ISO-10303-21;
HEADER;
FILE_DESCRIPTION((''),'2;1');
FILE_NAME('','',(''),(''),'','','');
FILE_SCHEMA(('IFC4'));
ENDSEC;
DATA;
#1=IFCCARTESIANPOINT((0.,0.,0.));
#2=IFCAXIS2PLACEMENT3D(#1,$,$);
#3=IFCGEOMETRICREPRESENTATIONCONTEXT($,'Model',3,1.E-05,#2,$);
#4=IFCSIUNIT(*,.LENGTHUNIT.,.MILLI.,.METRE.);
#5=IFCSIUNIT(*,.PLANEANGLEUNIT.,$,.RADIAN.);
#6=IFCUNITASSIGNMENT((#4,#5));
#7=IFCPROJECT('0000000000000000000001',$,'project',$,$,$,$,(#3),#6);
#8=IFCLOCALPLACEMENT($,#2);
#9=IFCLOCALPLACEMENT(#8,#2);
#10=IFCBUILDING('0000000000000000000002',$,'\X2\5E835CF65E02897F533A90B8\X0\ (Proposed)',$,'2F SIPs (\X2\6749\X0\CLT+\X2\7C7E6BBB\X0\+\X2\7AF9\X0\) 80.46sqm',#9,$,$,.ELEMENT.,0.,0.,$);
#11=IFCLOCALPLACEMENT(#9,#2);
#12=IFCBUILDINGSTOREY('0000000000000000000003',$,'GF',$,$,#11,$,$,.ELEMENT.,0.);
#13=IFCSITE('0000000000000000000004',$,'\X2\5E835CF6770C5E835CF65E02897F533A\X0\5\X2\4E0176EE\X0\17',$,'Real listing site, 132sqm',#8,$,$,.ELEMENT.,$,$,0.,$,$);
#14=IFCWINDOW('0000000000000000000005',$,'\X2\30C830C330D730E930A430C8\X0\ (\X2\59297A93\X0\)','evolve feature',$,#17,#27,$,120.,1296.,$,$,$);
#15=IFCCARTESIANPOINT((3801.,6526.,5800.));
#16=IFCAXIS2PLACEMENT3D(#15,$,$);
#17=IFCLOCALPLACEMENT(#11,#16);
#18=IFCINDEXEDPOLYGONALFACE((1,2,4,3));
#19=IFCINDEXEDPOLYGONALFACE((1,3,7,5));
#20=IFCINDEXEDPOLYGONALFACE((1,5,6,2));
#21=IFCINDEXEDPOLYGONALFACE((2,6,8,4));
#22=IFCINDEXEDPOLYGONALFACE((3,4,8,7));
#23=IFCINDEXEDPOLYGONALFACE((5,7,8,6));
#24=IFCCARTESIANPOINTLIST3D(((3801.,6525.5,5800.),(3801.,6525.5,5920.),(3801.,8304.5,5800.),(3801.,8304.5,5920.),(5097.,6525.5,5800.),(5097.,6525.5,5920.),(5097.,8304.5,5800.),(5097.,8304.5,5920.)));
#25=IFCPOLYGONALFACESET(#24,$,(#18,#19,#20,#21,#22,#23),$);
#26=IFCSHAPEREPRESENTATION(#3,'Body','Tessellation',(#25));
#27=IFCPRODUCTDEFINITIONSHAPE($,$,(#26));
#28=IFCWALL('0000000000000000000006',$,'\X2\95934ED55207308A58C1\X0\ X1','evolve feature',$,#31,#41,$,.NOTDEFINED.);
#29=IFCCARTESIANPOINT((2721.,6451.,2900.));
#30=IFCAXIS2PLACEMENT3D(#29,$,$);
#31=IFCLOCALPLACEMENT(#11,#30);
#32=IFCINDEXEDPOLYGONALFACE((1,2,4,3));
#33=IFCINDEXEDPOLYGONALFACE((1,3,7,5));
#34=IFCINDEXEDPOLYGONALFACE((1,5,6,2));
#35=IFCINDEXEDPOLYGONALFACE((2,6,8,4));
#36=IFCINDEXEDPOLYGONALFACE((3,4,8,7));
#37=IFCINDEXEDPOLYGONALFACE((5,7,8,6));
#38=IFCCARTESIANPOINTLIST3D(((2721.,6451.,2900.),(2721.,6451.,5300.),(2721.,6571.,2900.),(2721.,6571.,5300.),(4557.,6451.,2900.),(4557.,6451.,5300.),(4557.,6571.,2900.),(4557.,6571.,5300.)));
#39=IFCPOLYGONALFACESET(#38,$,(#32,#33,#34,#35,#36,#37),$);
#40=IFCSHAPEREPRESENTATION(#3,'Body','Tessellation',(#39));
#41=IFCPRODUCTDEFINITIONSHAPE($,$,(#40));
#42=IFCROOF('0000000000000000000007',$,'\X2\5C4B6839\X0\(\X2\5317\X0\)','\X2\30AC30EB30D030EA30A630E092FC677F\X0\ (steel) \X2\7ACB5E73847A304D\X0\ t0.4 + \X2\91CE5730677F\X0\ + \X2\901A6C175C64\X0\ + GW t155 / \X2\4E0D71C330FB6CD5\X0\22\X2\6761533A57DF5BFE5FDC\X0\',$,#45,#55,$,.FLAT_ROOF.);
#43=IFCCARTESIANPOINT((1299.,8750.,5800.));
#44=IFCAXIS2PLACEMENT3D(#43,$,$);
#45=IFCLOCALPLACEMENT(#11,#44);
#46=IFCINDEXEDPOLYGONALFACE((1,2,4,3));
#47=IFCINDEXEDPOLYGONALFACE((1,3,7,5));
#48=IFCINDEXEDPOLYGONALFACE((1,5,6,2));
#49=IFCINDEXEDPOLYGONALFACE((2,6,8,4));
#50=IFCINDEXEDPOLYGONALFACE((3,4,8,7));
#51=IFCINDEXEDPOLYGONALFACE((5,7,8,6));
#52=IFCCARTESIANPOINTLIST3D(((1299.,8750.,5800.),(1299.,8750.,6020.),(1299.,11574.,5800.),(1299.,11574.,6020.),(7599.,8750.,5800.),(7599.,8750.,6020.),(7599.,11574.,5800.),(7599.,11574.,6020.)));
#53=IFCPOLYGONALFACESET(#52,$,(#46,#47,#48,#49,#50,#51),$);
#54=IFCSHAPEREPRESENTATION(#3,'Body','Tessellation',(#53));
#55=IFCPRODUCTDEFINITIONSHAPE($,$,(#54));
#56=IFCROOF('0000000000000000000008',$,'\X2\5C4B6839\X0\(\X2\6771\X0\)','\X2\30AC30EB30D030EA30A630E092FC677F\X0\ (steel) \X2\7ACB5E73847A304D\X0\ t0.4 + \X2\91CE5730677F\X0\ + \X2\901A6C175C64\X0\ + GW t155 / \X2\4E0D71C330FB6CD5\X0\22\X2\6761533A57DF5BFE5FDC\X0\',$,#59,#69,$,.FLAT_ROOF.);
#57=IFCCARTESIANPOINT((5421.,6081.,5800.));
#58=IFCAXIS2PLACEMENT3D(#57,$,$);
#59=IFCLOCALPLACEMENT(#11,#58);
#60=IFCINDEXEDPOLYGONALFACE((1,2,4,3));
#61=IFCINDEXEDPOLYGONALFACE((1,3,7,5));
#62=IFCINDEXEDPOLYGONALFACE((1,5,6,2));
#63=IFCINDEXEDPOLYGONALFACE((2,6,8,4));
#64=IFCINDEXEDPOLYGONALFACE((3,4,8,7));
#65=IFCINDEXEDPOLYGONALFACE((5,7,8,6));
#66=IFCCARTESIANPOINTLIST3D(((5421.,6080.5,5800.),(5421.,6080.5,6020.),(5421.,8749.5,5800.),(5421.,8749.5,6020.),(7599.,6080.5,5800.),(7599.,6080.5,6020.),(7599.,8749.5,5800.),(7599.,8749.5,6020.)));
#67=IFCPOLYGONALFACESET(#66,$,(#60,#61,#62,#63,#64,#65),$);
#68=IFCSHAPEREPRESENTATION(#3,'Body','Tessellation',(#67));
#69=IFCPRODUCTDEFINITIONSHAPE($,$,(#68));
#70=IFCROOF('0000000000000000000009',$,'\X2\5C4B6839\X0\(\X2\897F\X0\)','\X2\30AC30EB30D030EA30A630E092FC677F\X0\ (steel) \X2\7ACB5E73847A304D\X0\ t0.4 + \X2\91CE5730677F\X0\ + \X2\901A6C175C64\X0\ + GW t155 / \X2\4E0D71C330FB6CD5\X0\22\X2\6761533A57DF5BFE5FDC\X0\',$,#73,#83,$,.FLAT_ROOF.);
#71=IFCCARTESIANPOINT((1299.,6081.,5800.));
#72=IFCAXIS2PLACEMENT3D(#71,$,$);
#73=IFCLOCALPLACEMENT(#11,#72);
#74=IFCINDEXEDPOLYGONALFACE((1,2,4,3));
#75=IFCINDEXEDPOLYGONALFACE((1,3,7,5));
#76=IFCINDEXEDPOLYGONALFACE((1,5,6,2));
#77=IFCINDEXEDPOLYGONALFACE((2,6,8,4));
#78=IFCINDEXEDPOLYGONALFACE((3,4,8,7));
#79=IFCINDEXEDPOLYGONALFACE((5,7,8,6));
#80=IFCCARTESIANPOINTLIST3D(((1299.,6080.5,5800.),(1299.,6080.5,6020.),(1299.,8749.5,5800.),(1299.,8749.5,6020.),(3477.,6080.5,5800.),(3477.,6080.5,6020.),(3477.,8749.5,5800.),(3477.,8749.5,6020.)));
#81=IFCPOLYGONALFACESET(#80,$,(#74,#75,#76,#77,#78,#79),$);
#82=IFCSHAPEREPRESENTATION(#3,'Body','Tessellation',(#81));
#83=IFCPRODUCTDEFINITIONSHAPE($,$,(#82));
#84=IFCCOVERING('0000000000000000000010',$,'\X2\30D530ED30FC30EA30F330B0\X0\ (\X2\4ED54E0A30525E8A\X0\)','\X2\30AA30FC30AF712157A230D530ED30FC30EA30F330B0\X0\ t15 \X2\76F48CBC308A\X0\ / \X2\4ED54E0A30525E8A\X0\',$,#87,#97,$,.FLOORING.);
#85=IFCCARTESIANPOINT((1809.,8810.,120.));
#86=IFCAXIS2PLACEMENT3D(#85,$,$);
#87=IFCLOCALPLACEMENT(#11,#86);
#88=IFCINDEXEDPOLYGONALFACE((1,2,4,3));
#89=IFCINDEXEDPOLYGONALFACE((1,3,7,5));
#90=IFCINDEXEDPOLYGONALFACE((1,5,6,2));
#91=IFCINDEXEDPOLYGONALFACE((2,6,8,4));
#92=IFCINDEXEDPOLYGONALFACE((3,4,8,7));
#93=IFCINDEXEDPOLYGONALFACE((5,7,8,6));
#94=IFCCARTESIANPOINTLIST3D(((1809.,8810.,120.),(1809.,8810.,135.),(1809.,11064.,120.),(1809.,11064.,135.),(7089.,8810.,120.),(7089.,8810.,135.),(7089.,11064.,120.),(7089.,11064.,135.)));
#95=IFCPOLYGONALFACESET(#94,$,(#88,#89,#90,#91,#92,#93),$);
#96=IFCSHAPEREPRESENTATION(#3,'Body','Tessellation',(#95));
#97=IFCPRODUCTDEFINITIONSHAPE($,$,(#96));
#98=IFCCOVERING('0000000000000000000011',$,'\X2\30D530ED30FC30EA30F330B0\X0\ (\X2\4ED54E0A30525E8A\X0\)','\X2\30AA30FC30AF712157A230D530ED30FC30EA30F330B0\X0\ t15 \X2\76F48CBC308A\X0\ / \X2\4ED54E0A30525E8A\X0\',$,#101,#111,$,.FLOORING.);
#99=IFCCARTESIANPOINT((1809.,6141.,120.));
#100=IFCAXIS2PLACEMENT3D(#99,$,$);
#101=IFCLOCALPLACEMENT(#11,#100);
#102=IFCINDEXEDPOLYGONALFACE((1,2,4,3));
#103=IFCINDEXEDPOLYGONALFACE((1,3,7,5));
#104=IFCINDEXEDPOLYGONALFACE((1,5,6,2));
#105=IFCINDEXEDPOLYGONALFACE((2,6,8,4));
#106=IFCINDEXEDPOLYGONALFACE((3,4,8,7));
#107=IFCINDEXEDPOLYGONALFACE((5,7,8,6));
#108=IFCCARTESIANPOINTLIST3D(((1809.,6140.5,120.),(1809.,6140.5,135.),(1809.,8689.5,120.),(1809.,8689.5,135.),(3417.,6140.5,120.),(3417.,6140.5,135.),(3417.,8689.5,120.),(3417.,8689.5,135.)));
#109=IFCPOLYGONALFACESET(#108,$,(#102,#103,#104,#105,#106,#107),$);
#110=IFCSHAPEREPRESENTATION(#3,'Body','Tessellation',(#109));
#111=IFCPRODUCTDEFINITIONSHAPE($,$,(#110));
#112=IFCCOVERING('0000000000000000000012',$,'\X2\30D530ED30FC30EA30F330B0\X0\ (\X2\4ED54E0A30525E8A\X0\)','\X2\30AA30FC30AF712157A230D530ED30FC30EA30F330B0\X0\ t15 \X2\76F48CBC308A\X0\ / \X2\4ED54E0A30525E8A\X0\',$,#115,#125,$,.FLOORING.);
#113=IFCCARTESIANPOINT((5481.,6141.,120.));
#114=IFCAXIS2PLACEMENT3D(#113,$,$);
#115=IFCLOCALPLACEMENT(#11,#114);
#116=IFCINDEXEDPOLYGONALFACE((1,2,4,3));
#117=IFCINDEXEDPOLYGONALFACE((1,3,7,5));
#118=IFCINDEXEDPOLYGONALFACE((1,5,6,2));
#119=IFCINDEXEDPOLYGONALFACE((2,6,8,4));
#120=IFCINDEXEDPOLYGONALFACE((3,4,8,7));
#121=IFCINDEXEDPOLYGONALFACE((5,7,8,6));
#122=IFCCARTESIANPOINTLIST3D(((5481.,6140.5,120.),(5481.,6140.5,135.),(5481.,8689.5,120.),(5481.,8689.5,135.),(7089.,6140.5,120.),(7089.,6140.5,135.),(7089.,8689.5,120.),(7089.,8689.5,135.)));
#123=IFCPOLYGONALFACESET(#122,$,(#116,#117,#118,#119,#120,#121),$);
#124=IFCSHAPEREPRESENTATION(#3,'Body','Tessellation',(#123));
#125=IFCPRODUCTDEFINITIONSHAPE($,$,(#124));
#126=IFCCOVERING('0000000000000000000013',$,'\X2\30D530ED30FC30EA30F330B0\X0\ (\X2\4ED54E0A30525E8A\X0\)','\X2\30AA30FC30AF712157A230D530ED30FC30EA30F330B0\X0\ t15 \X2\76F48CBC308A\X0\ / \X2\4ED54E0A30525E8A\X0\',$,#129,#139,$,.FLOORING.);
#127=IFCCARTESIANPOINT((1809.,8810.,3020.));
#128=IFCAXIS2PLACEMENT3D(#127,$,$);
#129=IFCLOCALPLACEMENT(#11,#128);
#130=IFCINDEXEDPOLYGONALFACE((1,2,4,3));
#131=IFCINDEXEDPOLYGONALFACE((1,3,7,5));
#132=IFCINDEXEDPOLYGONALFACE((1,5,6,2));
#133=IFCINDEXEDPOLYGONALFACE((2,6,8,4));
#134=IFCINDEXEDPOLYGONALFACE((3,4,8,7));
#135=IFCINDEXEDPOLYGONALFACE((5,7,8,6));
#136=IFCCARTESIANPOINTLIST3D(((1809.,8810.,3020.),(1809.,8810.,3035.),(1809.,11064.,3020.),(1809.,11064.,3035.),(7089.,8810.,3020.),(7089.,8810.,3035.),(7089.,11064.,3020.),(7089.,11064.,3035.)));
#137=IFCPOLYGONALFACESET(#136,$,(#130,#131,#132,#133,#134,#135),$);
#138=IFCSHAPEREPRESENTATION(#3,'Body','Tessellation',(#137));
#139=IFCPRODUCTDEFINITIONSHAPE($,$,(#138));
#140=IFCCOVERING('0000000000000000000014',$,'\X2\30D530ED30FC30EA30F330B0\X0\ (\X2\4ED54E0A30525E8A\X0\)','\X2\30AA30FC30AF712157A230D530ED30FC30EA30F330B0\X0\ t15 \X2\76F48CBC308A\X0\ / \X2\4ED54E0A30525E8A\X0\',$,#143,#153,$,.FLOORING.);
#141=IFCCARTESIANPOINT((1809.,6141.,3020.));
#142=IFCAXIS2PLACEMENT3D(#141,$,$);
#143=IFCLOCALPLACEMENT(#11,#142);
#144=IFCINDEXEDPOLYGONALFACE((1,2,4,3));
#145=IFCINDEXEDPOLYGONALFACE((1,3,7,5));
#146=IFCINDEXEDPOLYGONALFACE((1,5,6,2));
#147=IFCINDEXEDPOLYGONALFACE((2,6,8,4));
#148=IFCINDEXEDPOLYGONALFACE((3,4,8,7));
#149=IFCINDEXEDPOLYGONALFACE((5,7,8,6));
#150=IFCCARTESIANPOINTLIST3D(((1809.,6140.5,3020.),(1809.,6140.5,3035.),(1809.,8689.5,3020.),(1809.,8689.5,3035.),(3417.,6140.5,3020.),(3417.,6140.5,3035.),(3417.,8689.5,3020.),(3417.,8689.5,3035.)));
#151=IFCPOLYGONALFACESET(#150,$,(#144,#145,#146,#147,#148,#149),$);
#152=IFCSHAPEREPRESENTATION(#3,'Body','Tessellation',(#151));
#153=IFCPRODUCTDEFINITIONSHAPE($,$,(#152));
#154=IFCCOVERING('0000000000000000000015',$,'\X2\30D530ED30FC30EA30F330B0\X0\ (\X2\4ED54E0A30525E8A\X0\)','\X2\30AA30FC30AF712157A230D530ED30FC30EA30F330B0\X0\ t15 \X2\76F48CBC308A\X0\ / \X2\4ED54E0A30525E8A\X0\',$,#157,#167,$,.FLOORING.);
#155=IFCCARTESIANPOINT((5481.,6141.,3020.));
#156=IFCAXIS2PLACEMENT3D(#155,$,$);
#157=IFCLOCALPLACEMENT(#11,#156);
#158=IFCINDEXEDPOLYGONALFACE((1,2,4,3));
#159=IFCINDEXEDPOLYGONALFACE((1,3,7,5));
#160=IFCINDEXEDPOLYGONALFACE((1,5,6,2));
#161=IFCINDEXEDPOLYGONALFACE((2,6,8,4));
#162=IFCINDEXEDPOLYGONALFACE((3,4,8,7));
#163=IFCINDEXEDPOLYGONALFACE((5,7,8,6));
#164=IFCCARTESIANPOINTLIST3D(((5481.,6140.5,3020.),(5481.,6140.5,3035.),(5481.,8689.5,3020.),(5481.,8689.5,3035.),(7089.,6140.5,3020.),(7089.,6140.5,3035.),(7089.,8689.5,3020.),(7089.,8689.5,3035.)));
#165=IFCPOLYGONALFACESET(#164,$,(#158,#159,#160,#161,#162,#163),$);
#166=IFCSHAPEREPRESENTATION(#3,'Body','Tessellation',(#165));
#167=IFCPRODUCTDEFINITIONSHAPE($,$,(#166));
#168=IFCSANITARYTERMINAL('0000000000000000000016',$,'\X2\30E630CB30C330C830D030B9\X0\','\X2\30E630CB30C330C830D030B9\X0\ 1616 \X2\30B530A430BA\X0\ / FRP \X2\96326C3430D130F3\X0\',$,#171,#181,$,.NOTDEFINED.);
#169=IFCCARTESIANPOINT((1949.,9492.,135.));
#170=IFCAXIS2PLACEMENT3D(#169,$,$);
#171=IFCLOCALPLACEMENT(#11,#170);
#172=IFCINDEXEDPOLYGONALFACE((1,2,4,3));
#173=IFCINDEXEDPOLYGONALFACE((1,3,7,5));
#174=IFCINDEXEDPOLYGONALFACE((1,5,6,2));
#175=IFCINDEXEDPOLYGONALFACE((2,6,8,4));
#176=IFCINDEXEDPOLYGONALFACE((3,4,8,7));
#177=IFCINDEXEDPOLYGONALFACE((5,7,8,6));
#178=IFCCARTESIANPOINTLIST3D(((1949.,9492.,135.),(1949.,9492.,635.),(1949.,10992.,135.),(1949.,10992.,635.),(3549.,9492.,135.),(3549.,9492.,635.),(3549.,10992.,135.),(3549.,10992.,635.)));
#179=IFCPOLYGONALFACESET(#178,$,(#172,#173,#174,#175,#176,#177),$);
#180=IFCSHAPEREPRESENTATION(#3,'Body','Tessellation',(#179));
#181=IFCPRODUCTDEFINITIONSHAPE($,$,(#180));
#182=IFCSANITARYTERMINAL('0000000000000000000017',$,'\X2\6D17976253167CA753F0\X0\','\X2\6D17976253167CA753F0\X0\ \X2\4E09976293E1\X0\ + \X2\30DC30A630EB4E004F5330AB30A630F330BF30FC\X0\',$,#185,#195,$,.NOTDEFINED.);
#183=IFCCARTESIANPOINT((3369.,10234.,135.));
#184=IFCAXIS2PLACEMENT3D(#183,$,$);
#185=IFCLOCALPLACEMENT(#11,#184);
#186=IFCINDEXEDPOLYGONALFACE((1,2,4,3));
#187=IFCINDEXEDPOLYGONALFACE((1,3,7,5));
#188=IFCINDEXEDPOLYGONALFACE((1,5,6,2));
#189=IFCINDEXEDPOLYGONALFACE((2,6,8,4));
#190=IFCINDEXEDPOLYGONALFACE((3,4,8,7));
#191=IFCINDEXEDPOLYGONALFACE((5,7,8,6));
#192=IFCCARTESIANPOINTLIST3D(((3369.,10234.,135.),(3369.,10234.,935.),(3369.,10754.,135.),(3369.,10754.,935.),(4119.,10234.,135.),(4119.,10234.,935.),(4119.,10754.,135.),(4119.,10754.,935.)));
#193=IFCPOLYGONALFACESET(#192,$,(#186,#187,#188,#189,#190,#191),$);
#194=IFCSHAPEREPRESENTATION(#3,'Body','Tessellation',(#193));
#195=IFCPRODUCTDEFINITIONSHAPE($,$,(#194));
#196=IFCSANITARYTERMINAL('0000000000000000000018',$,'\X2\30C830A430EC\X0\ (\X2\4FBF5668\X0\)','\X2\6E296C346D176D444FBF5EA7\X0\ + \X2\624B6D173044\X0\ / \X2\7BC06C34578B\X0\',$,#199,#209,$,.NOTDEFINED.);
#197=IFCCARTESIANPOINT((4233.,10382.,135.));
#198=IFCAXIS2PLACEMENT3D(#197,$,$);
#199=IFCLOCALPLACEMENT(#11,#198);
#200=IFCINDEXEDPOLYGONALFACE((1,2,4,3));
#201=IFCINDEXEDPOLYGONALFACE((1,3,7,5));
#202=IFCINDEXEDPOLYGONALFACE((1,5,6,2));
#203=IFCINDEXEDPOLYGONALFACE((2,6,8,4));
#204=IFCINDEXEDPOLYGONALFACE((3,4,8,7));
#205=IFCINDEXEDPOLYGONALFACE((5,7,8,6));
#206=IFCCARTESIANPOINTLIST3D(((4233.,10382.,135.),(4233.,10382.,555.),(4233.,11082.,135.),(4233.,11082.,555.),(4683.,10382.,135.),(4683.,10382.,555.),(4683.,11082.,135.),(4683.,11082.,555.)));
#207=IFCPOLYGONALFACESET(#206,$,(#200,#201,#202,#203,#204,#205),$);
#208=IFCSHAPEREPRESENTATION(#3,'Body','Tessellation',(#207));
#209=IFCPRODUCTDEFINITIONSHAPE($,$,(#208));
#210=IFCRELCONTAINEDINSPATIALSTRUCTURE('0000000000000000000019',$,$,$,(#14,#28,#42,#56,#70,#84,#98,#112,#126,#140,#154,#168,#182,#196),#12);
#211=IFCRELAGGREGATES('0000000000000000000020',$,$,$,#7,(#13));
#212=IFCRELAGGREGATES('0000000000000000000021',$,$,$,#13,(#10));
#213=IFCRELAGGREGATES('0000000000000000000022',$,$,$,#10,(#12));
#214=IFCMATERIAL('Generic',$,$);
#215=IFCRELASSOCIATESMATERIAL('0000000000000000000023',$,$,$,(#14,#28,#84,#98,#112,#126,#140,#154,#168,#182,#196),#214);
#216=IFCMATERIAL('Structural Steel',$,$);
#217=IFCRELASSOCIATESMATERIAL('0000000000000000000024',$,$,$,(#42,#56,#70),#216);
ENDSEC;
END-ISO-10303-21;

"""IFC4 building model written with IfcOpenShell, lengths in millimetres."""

from ifc_helpers import new_model, si_unit, frame, frame_2d, origin, place, context, project, spatial, rectangle, extrude, material, element, save


model = new_model("IFC4")

# Units and contexts
model_context = context("Model", 3, precision=1e-05, world=origin())
ifc_project = project(units=[si_unit("LENGTHUNIT", "METRE", prefix="MILLI"), si_unit("PLANEANGLEUNIT", "RADIAN")], contexts=[model_context])

# Site, building, storey
site_placement = place(None, origin())
site = spatial("IfcSite", under=ifc_project, at=site_placement, Name="広島県広島市西区5丁目17", ObjectType="Real listing site, 132sqm", CompositionType="ELEMENT", RefElevation=0.0)
building_placement = place(site_placement, origin())
building = spatial("IfcBuilding", under=site, at=building_placement, Name="広島市西区邸 (Proposed)", ObjectType="2F SIPs (杉CLT+籾殻+竹) 80.46sqm", CompositionType="ELEMENT", ElevationOfRefHeight=0.0, ElevationOfTerrain=0.0)
storey_placement = place(building_placement, origin())
storey = spatial("IfcBuildingStorey", under=building, at=storey_placement, Name="GF", CompositionType="ELEMENT", Elevation=0.0)

# Window
ifc_material_1 = material(Name="Generic")
window_1_placement = place(storey_placement, frame((3801.0, 6526.0, 5800.0)))
element("IfcWindow", 1, at=window_1_placement, inside=storey, material=ifc_material_1, Name="トップライト (天窓)", Description="evolve feature", OverallHeight=120.0, OverallWidth=1296.0, context=model_context, shape_type="SweptSolid", body=[
    extrude(rectangle(XDim=1296.0, YDim=1779.0, at=frame_2d((648.0, 889.0))), frame((3801.0, 6526.0, 5800.0)), (0.0, 0.0, 1.0), 120.0),
])

# Wall
wall_1_placement = place(storey_placement, frame((2721.0, 6451.0, 2900.0)))
element("IfcWall", 2, at=wall_1_placement, inside=storey, material=ifc_material_1, Name="間仕切り壁 X1", Description="evolve feature", PredefinedType="NOTDEFINED", context=model_context, shape_type="SweptSolid", body=[
    extrude(rectangle(XDim=1836.0, YDim=120.0, at=frame_2d((918.0, 60.0))), frame((2721.0, 6451.0, 2900.0)), (0.0, 0.0, 1.0), 2400.0),
])

# Roofs
ifc_material_2 = material(Name="Structural Steel")
roof_1_placement = place(storey_placement, frame((1299.0, 8750.0, 5800.0)))
element("IfcRoof", 3, at=roof_1_placement, inside=storey, material=ifc_material_2, Name="屋根(北)", Description="ガルバリウム鋼板 (steel) 立平葺き t0.4 + 野地板 + 通気層 + GW t155 / 不燃・法22条区域対応", PredefinedType="FLAT_ROOF", context=model_context, shape_type="SweptSolid", body=[
    extrude(rectangle(XDim=6300.0, YDim=2824.0, at=frame_2d((3150.0, 1412.0))), frame((1299.0, 8750.0, 5800.0)), (0.0, 0.0, 1.0), 220.0),
])
roof_2_placement = place(storey_placement, frame((5421.0, 6081.0, 5800.0)))
element("IfcRoof", 4, at=roof_2_placement, inside=storey, material=ifc_material_2, Name="屋根(東)", Description="ガルバリウム鋼板 (steel) 立平葺き t0.4 + 野地板 + 通気層 + GW t155 / 不燃・法22条区域対応", PredefinedType="FLAT_ROOF", context=model_context, shape_type="SweptSolid", body=[
    extrude(rectangle(XDim=2178.0, YDim=2669.0, at=frame_2d((1089.0, 1334.0))), frame((5421.0, 6081.0, 5800.0)), (0.0, 0.0, 1.0), 220.0),
])
roof_3_placement = place(storey_placement, frame((1299.0, 6081.0, 5800.0)))
element("IfcRoof", 5, at=roof_3_placement, inside=storey, material=ifc_material_2, Name="屋根(西)", Description="ガルバリウム鋼板 (steel) 立平葺き t0.4 + 野地板 + 通気層 + GW t155 / 不燃・法22条区域対応", PredefinedType="FLAT_ROOF", context=model_context, shape_type="SweptSolid", body=[
    extrude(rectangle(XDim=2178.0, YDim=2669.0, at=frame_2d((1089.0, 1334.0))), frame((1299.0, 6081.0, 5800.0)), (0.0, 0.0, 1.0), 220.0),
])

# Coverings
covering_1_placement = place(storey_placement, frame((1809.0, 8810.0, 120.0)))
element("IfcCovering", 6, at=covering_1_placement, inside=storey, material=ifc_material_1, Name="フローリング (仕上げ床)", Description="オーク無垢フローリング t15 直貼り / 仕上げ床", PredefinedType="FLOORING", context=model_context, shape_type="SweptSolid", body=[
    extrude(rectangle(XDim=5280.0, YDim=2254.0, at=frame_2d((2640.0, 1127.0))), frame((1809.0, 8810.0, 120.0)), (0.0, 0.0, 1.0), 15.0),
])
covering_2_placement = place(storey_placement, frame((1809.0, 6141.0, 120.0)))
element("IfcCovering", 7, at=covering_2_placement, inside=storey, material=ifc_material_1, Name="フローリング (仕上げ床)", Description="オーク無垢フローリング t15 直貼り / 仕上げ床", PredefinedType="FLOORING", context=model_context, shape_type="SweptSolid", body=[
    extrude(rectangle(XDim=1608.0, YDim=2549.0, at=frame_2d((804.0, 1274.0))), frame((1809.0, 6141.0, 120.0)), (0.0, 0.0, 1.0), 15.0),
])
covering_3_placement = place(storey_placement, frame((5481.0, 6141.0, 120.0)))
element("IfcCovering", 8, at=covering_3_placement, inside=storey, material=ifc_material_1, Name="フローリング (仕上げ床)", Description="オーク無垢フローリング t15 直貼り / 仕上げ床", PredefinedType="FLOORING", context=model_context, shape_type="SweptSolid", body=[
    extrude(rectangle(XDim=1608.0, YDim=2549.0, at=frame_2d((804.0, 1274.0))), frame((5481.0, 6141.0, 120.0)), (0.0, 0.0, 1.0), 15.0),
])
covering_4_placement = place(storey_placement, frame((1809.0, 8810.0, 3020.0)))
element("IfcCovering", 9, at=covering_4_placement, inside=storey, material=ifc_material_1, Name="フローリング (仕上げ床)", Description="オーク無垢フローリング t15 直貼り / 仕上げ床", PredefinedType="FLOORING", context=model_context, shape_type="SweptSolid", body=[
    extrude(rectangle(XDim=5280.0, YDim=2254.0, at=frame_2d((2640.0, 1127.0))), frame((1809.0, 8810.0, 3020.0)), (0.0, 0.0, 1.0), 15.0),
])
covering_5_placement = place(storey_placement, frame((1809.0, 6141.0, 3020.0)))
element("IfcCovering", 10, at=covering_5_placement, inside=storey, material=ifc_material_1, Name="フローリング (仕上げ床)", Description="オーク無垢フローリング t15 直貼り / 仕上げ床", PredefinedType="FLOORING", context=model_context, shape_type="SweptSolid", body=[
    extrude(rectangle(XDim=1608.0, YDim=2549.0, at=frame_2d((804.0, 1274.0))), frame((1809.0, 6141.0, 3020.0)), (0.0, 0.0, 1.0), 15.0),
])
covering_6_placement = place(storey_placement, frame((5481.0, 6141.0, 3020.0)))
element("IfcCovering", 11, at=covering_6_placement, inside=storey, material=ifc_material_1, Name="フローリング (仕上げ床)", Description="オーク無垢フローリング t15 直貼り / 仕上げ床", PredefinedType="FLOORING", context=model_context, shape_type="SweptSolid", body=[
    extrude(rectangle(XDim=1608.0, YDim=2549.0, at=frame_2d((804.0, 1274.0))), frame((5481.0, 6141.0, 3020.0)), (0.0, 0.0, 1.0), 15.0),
])

# Sanitary terminals
sanitary_terminal_1_placement = place(storey_placement, frame((1949.0, 9492.0, 135.0)))
element("IfcSanitaryTerminal", 12, at=sanitary_terminal_1_placement, inside=storey, material=ifc_material_1, Name="ユニットバス", Description="ユニットバス 1616 サイズ / FRP 防水パン", PredefinedType="NOTDEFINED", context=model_context, shape_type="SweptSolid", body=[
    extrude(rectangle(XDim=1600.0, YDim=1500.0, at=frame_2d((800.0, 750.0))), frame((1949.0, 9492.0, 135.0)), (0.0, 0.0, 1.0), 500.0),
])
sanitary_terminal_2_placement = place(storey_placement, frame((3369.0, 10234.0, 135.0)))
element("IfcSanitaryTerminal", 13, at=sanitary_terminal_2_placement, inside=storey, material=ifc_material_1, Name="洗面化粧台", Description="洗面化粧台 三面鏡 + ボウル一体カウンター", PredefinedType="NOTDEFINED", context=model_context, shape_type="SweptSolid", body=[
    extrude(rectangle(XDim=750.0, YDim=520.0, at=frame_2d((375.0, 260.0))), frame((3369.0, 10234.0, 135.0)), (0.0, 0.0, 1.0), 800.0),
])
sanitary_terminal_3_placement = place(storey_placement, frame((4233.0, 10382.0, 135.0)))
element("IfcSanitaryTerminal", 14, at=sanitary_terminal_3_placement, inside=storey, material=ifc_material_1, Name="トイレ (便器)", Description="温水洗浄便座 + 手洗い / 節水型", PredefinedType="NOTDEFINED", context=model_context, shape_type="SweptSolid", body=[
    extrude(rectangle(XDim=450.0, YDim=700.0, at=frame_2d((225.0, 350.0))), frame((4233.0, 10382.0, 135.0)), (0.0, 0.0, 1.0), 420.0),
])

save(model, "model.ifc")
